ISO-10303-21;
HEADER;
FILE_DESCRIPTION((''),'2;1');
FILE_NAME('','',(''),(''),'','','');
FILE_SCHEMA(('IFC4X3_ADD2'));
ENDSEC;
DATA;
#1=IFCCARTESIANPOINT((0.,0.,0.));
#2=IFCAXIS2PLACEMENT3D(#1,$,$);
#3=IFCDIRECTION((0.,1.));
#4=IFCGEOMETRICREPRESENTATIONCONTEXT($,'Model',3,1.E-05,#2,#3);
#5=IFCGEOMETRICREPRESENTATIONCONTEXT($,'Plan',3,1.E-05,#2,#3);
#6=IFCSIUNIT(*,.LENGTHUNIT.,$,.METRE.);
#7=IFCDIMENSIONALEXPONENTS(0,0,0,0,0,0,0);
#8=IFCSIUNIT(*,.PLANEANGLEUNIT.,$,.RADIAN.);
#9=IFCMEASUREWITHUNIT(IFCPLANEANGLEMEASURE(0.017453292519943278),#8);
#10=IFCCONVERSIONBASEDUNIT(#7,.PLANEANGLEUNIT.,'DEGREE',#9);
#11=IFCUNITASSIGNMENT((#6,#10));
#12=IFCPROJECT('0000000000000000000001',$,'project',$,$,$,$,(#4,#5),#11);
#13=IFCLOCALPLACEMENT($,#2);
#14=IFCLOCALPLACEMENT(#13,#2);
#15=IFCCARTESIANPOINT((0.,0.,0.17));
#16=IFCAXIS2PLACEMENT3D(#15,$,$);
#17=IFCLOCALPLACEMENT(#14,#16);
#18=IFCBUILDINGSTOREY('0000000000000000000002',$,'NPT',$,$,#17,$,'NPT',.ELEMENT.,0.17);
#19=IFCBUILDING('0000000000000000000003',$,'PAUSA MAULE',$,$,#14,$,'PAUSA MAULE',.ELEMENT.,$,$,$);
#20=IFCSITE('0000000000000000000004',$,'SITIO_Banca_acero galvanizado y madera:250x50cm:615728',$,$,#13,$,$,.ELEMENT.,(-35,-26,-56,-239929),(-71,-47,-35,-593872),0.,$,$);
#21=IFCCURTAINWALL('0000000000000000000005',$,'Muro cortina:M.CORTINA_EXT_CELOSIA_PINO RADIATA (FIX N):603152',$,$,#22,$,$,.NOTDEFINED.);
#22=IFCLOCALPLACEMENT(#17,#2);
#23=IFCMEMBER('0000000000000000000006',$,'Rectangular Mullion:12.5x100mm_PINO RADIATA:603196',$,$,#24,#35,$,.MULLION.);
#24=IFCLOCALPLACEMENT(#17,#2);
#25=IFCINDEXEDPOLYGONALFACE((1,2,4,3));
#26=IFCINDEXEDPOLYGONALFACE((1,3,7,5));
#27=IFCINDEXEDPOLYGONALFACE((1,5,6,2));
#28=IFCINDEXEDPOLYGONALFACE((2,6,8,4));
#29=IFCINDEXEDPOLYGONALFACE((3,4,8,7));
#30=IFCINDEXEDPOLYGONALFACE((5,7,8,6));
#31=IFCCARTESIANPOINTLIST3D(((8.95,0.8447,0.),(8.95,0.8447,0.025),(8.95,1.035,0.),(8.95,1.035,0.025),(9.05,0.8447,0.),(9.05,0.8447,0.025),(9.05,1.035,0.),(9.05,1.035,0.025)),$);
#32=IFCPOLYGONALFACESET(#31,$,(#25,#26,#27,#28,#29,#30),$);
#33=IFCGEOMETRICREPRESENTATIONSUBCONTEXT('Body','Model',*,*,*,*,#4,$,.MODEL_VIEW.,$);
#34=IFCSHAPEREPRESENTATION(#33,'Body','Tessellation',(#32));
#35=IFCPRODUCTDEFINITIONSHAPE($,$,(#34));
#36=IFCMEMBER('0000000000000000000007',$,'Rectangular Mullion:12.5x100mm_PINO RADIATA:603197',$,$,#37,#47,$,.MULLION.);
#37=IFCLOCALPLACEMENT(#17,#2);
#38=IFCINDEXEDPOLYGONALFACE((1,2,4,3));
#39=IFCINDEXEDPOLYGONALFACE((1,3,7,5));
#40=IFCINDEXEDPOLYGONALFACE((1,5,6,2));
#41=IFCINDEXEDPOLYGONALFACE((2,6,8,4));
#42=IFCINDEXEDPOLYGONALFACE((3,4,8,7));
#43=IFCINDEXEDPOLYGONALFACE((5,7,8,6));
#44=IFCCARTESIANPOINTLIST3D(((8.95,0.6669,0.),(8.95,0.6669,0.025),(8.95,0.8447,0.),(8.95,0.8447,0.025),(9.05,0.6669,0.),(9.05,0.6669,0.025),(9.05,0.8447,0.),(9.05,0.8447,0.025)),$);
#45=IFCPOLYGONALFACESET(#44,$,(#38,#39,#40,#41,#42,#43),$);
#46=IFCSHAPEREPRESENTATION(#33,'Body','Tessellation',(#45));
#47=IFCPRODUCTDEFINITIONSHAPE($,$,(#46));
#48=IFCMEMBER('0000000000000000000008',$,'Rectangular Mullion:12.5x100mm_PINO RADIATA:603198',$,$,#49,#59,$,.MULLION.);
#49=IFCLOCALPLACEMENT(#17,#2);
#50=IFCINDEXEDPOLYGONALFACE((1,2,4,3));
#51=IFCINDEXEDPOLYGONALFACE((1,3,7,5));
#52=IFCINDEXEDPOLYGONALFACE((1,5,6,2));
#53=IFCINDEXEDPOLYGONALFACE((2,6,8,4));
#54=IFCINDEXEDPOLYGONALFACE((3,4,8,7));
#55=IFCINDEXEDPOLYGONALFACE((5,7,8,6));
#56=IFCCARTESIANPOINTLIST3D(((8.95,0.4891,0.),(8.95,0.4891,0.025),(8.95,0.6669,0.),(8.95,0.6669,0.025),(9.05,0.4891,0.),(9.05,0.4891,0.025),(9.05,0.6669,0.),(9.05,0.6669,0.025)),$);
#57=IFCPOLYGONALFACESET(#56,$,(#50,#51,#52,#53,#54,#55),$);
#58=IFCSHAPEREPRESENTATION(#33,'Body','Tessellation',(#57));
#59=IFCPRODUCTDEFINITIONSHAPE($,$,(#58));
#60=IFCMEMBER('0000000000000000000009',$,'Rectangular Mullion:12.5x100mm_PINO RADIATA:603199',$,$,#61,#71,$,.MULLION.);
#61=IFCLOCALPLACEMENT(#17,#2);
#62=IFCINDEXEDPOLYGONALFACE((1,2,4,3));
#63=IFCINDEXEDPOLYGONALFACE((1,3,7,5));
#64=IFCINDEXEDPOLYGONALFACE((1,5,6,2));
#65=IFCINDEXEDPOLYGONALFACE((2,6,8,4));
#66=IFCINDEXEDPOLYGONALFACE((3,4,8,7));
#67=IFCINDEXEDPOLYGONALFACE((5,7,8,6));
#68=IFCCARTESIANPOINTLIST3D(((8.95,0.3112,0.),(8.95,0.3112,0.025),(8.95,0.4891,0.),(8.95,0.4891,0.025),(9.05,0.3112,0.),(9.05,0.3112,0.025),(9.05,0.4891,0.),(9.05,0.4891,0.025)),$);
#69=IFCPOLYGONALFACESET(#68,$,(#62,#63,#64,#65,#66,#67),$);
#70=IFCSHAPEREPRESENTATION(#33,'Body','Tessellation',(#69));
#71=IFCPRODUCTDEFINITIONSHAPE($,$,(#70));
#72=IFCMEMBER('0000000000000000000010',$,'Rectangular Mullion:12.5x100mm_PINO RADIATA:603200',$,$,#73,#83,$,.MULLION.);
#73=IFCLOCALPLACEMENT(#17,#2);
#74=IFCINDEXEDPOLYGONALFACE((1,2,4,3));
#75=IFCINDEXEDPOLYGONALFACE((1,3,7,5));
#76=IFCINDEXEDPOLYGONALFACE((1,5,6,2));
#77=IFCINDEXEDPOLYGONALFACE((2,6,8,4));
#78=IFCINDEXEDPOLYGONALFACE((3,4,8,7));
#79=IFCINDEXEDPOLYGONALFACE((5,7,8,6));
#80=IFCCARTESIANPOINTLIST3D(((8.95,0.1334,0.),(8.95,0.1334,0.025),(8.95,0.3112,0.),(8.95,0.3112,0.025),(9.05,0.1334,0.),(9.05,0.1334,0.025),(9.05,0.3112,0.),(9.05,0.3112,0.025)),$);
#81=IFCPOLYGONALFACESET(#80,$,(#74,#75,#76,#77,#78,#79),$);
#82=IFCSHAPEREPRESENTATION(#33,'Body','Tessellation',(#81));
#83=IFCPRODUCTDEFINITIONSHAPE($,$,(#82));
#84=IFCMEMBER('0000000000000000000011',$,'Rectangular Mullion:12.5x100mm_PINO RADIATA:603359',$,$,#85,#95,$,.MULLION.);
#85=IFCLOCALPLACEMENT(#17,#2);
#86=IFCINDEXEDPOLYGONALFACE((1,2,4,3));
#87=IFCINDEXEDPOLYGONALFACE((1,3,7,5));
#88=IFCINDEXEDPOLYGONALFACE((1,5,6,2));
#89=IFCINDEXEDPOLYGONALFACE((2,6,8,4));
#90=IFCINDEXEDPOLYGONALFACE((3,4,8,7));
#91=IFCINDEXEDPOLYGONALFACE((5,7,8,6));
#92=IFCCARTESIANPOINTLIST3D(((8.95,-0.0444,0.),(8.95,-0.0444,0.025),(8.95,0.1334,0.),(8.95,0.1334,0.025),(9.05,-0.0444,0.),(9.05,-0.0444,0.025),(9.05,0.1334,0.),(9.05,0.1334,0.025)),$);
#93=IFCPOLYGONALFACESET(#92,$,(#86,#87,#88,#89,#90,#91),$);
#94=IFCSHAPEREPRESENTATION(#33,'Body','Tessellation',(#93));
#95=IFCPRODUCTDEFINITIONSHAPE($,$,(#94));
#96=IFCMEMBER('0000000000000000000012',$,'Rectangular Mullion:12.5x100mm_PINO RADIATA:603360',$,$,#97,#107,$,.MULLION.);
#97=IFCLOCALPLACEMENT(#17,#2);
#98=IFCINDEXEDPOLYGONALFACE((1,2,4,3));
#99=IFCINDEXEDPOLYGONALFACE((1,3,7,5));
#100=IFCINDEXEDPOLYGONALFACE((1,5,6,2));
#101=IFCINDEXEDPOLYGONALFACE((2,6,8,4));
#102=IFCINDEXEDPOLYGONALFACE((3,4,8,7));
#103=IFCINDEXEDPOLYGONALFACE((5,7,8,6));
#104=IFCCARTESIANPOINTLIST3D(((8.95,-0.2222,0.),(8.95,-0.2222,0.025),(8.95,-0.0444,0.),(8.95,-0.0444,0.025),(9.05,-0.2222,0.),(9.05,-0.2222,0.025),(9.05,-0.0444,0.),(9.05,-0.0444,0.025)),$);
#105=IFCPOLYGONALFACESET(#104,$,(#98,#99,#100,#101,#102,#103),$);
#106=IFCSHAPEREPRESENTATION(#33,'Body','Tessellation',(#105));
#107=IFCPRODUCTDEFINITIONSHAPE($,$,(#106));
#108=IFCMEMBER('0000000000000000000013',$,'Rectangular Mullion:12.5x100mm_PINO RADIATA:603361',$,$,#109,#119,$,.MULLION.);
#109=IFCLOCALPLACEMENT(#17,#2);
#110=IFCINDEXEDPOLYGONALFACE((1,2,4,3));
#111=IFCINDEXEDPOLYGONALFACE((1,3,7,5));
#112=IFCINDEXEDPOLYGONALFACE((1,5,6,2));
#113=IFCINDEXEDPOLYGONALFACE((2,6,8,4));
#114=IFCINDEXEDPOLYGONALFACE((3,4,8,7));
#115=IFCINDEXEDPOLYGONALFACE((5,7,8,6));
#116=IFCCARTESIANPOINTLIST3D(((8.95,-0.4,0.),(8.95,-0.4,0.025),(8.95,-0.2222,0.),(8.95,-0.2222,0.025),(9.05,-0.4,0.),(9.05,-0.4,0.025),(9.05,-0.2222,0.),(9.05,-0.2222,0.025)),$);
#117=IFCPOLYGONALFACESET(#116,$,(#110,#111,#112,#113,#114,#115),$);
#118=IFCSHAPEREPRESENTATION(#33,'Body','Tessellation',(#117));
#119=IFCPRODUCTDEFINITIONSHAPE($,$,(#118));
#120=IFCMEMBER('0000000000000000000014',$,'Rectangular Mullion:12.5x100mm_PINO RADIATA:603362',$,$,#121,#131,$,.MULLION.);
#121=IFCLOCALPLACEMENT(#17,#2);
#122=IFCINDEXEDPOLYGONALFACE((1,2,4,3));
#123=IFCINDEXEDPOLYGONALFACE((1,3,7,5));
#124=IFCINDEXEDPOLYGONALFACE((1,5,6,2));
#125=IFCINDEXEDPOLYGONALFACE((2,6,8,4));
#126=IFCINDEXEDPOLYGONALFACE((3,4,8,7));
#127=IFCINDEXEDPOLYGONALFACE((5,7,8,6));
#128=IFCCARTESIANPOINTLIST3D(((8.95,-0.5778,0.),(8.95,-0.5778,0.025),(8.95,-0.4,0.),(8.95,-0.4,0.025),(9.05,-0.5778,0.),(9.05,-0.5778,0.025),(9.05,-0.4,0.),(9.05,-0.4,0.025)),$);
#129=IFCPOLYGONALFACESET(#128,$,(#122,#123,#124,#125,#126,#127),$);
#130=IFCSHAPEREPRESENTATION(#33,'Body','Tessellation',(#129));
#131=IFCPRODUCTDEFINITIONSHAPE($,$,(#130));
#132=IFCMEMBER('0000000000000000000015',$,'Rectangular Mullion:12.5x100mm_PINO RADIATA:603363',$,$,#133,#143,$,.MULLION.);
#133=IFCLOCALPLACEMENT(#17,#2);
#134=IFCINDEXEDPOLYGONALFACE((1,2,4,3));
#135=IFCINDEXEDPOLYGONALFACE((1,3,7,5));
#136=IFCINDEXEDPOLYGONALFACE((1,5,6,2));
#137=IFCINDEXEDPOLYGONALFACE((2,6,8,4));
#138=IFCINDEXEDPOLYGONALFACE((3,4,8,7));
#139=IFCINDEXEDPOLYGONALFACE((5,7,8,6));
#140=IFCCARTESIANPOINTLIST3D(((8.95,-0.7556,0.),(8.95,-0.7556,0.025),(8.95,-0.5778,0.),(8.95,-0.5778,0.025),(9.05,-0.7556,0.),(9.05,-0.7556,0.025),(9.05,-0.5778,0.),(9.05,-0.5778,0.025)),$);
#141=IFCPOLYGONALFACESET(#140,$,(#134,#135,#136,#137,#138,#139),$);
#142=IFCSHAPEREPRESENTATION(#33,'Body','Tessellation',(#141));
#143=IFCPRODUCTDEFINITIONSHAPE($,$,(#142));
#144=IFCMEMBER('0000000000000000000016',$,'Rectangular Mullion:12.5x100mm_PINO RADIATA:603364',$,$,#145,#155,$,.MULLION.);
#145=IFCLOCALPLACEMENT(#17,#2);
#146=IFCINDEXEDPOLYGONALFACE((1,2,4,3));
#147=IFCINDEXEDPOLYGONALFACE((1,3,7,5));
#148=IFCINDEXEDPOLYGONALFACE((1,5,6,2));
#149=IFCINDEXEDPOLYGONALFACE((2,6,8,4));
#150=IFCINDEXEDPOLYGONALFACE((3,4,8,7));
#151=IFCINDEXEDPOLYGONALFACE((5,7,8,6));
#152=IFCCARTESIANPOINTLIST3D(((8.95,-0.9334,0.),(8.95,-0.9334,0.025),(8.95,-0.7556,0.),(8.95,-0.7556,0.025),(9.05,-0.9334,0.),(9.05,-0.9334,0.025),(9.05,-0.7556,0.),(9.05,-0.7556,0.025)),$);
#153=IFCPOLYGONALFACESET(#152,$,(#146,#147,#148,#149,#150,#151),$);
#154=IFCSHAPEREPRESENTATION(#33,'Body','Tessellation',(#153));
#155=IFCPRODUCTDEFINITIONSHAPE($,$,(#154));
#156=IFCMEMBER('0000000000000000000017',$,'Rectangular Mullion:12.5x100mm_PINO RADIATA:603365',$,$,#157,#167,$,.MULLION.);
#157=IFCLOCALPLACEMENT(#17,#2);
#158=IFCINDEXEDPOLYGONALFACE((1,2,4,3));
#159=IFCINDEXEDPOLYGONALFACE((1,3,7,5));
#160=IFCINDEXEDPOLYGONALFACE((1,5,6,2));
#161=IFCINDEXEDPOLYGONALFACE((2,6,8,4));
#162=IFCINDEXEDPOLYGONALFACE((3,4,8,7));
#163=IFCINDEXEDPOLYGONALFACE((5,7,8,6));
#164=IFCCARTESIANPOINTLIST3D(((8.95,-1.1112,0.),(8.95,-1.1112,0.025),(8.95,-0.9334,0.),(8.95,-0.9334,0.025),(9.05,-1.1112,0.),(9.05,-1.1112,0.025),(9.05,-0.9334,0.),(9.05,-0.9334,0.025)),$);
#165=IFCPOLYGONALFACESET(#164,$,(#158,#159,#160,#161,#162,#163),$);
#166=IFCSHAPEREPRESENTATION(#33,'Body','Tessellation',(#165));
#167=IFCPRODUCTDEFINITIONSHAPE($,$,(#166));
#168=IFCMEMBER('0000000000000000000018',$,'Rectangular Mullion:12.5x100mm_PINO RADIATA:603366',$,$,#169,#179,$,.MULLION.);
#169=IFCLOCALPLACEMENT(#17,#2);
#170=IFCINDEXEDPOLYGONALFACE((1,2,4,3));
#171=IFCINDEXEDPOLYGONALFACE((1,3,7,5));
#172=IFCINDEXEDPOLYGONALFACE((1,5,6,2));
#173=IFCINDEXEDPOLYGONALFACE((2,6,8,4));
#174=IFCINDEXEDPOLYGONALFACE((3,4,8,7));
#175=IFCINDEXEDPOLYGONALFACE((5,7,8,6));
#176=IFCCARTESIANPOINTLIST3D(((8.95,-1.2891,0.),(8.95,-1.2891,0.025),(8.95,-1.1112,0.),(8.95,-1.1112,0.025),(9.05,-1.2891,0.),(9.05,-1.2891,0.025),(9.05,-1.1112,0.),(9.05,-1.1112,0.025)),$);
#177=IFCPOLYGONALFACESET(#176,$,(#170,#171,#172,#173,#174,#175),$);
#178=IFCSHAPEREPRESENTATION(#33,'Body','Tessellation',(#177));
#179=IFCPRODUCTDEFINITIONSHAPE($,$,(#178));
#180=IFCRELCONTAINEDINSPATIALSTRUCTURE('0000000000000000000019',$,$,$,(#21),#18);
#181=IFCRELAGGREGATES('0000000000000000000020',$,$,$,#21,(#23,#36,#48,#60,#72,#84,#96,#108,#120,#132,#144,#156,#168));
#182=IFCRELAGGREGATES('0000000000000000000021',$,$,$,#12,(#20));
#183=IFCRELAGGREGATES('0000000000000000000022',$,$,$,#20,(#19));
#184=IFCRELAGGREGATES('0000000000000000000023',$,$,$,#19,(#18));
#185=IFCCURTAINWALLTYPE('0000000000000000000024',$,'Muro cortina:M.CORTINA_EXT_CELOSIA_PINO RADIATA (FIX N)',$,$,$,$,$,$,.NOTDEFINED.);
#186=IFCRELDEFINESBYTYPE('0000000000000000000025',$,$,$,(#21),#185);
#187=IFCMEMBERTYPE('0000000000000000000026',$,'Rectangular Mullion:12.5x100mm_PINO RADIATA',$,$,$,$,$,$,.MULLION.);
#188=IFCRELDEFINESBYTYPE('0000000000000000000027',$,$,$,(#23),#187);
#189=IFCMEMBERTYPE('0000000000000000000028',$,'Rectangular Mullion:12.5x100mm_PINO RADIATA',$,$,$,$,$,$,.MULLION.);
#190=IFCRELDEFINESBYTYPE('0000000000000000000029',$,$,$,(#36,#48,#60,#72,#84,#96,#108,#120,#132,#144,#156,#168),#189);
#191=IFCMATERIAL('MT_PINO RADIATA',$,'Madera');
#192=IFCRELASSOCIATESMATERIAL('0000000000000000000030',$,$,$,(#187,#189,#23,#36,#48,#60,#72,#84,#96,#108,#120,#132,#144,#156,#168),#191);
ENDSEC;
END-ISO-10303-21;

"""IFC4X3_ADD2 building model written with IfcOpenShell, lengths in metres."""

from ifc_helpers import new_model, entity, si_unit, converted_unit, direction, frame, frame_2d, origin, place, context, subcontext, project, spatial, rectangle, extrude, source, transform, mapped, material, material_profile, profile_set, profile_usage, type_object, type_shapes, element, aggregate, save


model = new_model("IFC4X3_ADD2")

# Units and contexts
model_context = context("Model", 3, precision=1e-05, world=origin(), true_north=direction((0.0, 1.0)))
plan_context = context("Plan", 3, precision=1e-05, world=origin(), true_north=direction((0.0, 1.0)))
body_context = subcontext(model_context, "Body", "Model", "MODEL_VIEW")
ifc_project = project(units=[si_unit("LENGTHUNIT", "METRE"), converted_unit("PLANEANGLEUNIT", "DEGREE", entity("IfcPlaneAngleMeasure", 0.017453292519943278), si_unit("PLANEANGLEUNIT", "RADIAN"), dimensions=[0, 0, 0, 0, 0, 0, 0])], contexts=[model_context, plan_context])

# Site, building, storey
site_placement = place(None, origin())
site = spatial("IfcSite", under=ifc_project, at=site_placement, Name="SITIO_Banca_acero galvanizado y madera:250x50cm:615728", CompositionType="ELEMENT", RefLatitude=(-35, -26, -56, -239929), RefLongitude=(-71, -47, -35, -593872), RefElevation=0.0)
building_placement = place(site_placement, origin())
building = spatial("IfcBuilding", under=site, at=building_placement, Name="PAUSA MAULE", LongName="PAUSA MAULE", CompositionType="ELEMENT")
storey_placement = place(building_placement, frame((0.0, 0.0, 0.17)))
storey = spatial("IfcBuildingStorey", under=building, at=storey_placement, Name="NPT", LongName="NPT", CompositionType="ELEMENT", Elevation=0.17)

# Curtain wall, members
curtain_wall_type = type_object("IfcCurtainWallType", Name="Muro cortina:M.CORTINA_EXT_CELOSIA_PINO RADIATA (FIX N)", PredefinedType="NOTDEFINED")
curtain_wall_placement = place(storey_placement, frame((0.0, 0.0, -0.17)))
curtain_wall = element("IfcCurtainWall", 1, at=curtain_wall_placement, inside=storey, type_object=curtain_wall_type, Name="Muro cortina:M.CORTINA_EXT_CELOSIA_PINO RADIATA (FIX N):603152", PredefinedType="NOTDEFINED")
ifc_material = material(Name="MT_PINO RADIATA", Category="Madera")
ifc_material_profile = material_profile(ifc_material, rectangle(XDim=0.025, YDim=0.1, at=frame_2d((0.0, 0.0), x_axis=(1.0, 0.0))), Name="12.5x100mm_PINO RADIATA")
ifc_profile_set = profile_set([ifc_material_profile], Name="12.5x100mm_PINO RADIATA")
ifc_profile_usage = profile_usage(ifc_profile_set)
member_type_1 = type_object("IfcMemberType", Name="Rectangular Mullion:12.5x100mm_PINO RADIATA", PredefinedType="MULLION", material=ifc_profile_set)
shared_shape_1 = source(origin(), body_context, "Body", "SweptSolid", [
    extrude(rectangle(XDim=0.025, YDim=0.1, at=frame_2d((0.0, 0.0), x_axis=(1.0, 0.0))), frame((-0.0125, 0.0, -0.1903), z_axis=(0.0, 0.0, 1.0), x_axis=(-1.0, 0.0, 0.0)), (0.0, 0.0, 1.0), 0.1903),
])
type_shapes(member_type_1, [shared_shape_1])
member_1_placement = place(curtain_wall_placement, frame((9.0, 1.035, 0.17), z_axis=(0.0, 1.0, 0.0), x_axis=(0.0, 0.0, -1.0)))
member_1 = element("IfcMember", 2, at=member_1_placement, type_object=member_type_1, material=ifc_profile_usage, Name="Rectangular Mullion:12.5x100mm_PINO RADIATA:603196", PredefinedType="MULLION", context=body_context, shape_type="MappedRepresentation", body=[
    mapped(shared_shape_1, transform((0.0, 0.0, 0.0), scale=1.0)),
])
member_type_2 = type_object("IfcMemberType", Name="Rectangular Mullion:12.5x100mm_PINO RADIATA", PredefinedType="MULLION", material=ifc_profile_set)
shared_shape_2 = source(origin(), body_context, "Body", "SweptSolid", [
    extrude(rectangle(XDim=0.025, YDim=0.1, at=frame_2d((0.0, 0.0), x_axis=(1.0, 0.0))), frame((-0.0125, 0.0, -0.1778), z_axis=(0.0, 0.0, 1.0), x_axis=(-1.0, 0.0, 0.0)), (0.0, 0.0, 1.0), 0.1778),
])
type_shapes(member_type_2, [shared_shape_2])
member_2_placement = place(curtain_wall_placement, frame((9.0, 0.8447, 0.17), z_axis=(0.0, 1.0, 0.0), x_axis=(0.0, 0.0, -1.0)))
member_2 = element("IfcMember", 3, at=member_2_placement, type_object=member_type_2, material=ifc_profile_usage, Name="Rectangular Mullion:12.5x100mm_PINO RADIATA:603197", PredefinedType="MULLION", context=body_context, shape_type="MappedRepresentation", body=[
    mapped(shared_shape_2, transform((0.0, 0.0, 0.0), scale=1.0)),
])
member_3_placement = place(curtain_wall_placement, frame((9.0, 0.6669, 0.17), z_axis=(0.0, 1.0, 0.0), x_axis=(0.0, 0.0, -1.0)))
member_3 = element("IfcMember", 4, at=member_3_placement, type_object=member_type_2, material=ifc_profile_usage, Name="Rectangular Mullion:12.5x100mm_PINO RADIATA:603198", PredefinedType="MULLION", context=body_context, shape_type="MappedRepresentation", body=[
    mapped(shared_shape_2, transform((0.0, 0.0, 0.0), scale=1.0)),
])
member_4_placement = place(curtain_wall_placement, frame((9.0, 0.4891, 0.17), z_axis=(0.0, 1.0, 0.0), x_axis=(0.0, 0.0, -1.0)))
member_4 = element("IfcMember", 5, at=member_4_placement, type_object=member_type_2, material=ifc_profile_usage, Name="Rectangular Mullion:12.5x100mm_PINO RADIATA:603199", PredefinedType="MULLION", context=body_context, shape_type="MappedRepresentation", body=[
    mapped(shared_shape_2, transform((0.0, 0.0, 0.0), scale=1.0)),
])
member_5_placement = place(curtain_wall_placement, frame((9.0, 0.3112, 0.17), z_axis=(0.0, 1.0, 0.0), x_axis=(0.0, 0.0, -1.0)))
member_5 = element("IfcMember", 6, at=member_5_placement, type_object=member_type_2, material=ifc_profile_usage, Name="Rectangular Mullion:12.5x100mm_PINO RADIATA:603200", PredefinedType="MULLION", context=body_context, shape_type="MappedRepresentation", body=[
    mapped(shared_shape_2, transform((0.0, 0.0, 0.0), scale=1.0)),
])
member_6_placement = place(curtain_wall_placement, frame((9.0, 0.1334, 0.17), z_axis=(0.0, 1.0, 0.0), x_axis=(0.0, 0.0, -1.0)))
member_6 = element("IfcMember", 7, at=member_6_placement, type_object=member_type_2, material=ifc_profile_usage, Name="Rectangular Mullion:12.5x100mm_PINO RADIATA:603359", PredefinedType="MULLION", context=body_context, shape_type="MappedRepresentation", body=[
    mapped(shared_shape_2, transform((0.0, 0.0, 0.0), scale=1.0)),
])
member_7_placement = place(curtain_wall_placement, frame((9.0, -0.0444, 0.17), z_axis=(0.0, 1.0, 0.0), x_axis=(0.0, 0.0, -1.0)))
member_7 = element("IfcMember", 8, at=member_7_placement, type_object=member_type_2, material=ifc_profile_usage, Name="Rectangular Mullion:12.5x100mm_PINO RADIATA:603360", PredefinedType="MULLION", context=body_context, shape_type="MappedRepresentation", body=[
    mapped(shared_shape_2, transform((0.0, 0.0, 0.0), scale=1.0)),
])
member_8_placement = place(curtain_wall_placement, frame((9.0, -0.2222, 0.17), z_axis=(0.0, 1.0, 0.0), x_axis=(0.0, 0.0, -1.0)))
member_8 = element("IfcMember", 9, at=member_8_placement, type_object=member_type_2, material=ifc_profile_usage, Name="Rectangular Mullion:12.5x100mm_PINO RADIATA:603361", PredefinedType="MULLION", context=body_context, shape_type="MappedRepresentation", body=[
    mapped(shared_shape_2, transform((0.0, 0.0, 0.0), scale=1.0)),
])
member_9_placement = place(curtain_wall_placement, frame((9.0, -0.4, 0.17), z_axis=(0.0, 1.0, 0.0), x_axis=(0.0, 0.0, -1.0)))
member_9 = element("IfcMember", 10, at=member_9_placement, type_object=member_type_2, material=ifc_profile_usage, Name="Rectangular Mullion:12.5x100mm_PINO RADIATA:603362", PredefinedType="MULLION", context=body_context, shape_type="MappedRepresentation", body=[
    mapped(shared_shape_2, transform((0.0, 0.0, 0.0), scale=1.0)),
])
member_10_placement = place(curtain_wall_placement, frame((9.0, -0.5778, 0.17), z_axis=(0.0, 1.0, 0.0), x_axis=(0.0, 0.0, -1.0)))
member_10 = element("IfcMember", 11, at=member_10_placement, type_object=member_type_2, material=ifc_profile_usage, Name="Rectangular Mullion:12.5x100mm_PINO RADIATA:603363", PredefinedType="MULLION", context=body_context, shape_type="MappedRepresentation", body=[
    mapped(shared_shape_2, transform((0.0, 0.0, 0.0), scale=1.0)),
])
member_11_placement = place(curtain_wall_placement, frame((9.0, -0.7556, 0.17), z_axis=(0.0, 1.0, 0.0), x_axis=(0.0, 0.0, -1.0)))
member_11 = element("IfcMember", 12, at=member_11_placement, type_object=member_type_2, material=ifc_profile_usage, Name="Rectangular Mullion:12.5x100mm_PINO RADIATA:603364", PredefinedType="MULLION", context=body_context, shape_type="MappedRepresentation", body=[
    mapped(shared_shape_2, transform((0.0, 0.0, 0.0), scale=1.0)),
])
member_12_placement = place(curtain_wall_placement, frame((9.0, -0.9334, 0.17), z_axis=(0.0, 1.0, 0.0), x_axis=(0.0, 0.0, -1.0)))
member_12 = element("IfcMember", 13, at=member_12_placement, type_object=member_type_2, material=ifc_profile_usage, Name="Rectangular Mullion:12.5x100mm_PINO RADIATA:603365", PredefinedType="MULLION", context=body_context, shape_type="MappedRepresentation", body=[
    mapped(shared_shape_2, transform((0.0, 0.0, 0.0), scale=1.0)),
])
member_13_placement = place(curtain_wall_placement, frame((9.0, -1.1112, 0.17), z_axis=(0.0, 1.0, 0.0), x_axis=(0.0, 0.0, -1.0)))
member_13 = element("IfcMember", 14, at=member_13_placement, type_object=member_type_2, material=ifc_profile_usage, Name="Rectangular Mullion:12.5x100mm_PINO RADIATA:603366", PredefinedType="MULLION", context=body_context, shape_type="MappedRepresentation", body=[
    mapped(shared_shape_2, transform((0.0, 0.0, 0.0), scale=1.0)),
])
aggregate(curtain_wall, [member_1, member_2, member_3, member_4, member_5, member_6, member_7, member_8, member_9, member_10, member_11, member_12, member_13])

save(model, "model.ifc")
